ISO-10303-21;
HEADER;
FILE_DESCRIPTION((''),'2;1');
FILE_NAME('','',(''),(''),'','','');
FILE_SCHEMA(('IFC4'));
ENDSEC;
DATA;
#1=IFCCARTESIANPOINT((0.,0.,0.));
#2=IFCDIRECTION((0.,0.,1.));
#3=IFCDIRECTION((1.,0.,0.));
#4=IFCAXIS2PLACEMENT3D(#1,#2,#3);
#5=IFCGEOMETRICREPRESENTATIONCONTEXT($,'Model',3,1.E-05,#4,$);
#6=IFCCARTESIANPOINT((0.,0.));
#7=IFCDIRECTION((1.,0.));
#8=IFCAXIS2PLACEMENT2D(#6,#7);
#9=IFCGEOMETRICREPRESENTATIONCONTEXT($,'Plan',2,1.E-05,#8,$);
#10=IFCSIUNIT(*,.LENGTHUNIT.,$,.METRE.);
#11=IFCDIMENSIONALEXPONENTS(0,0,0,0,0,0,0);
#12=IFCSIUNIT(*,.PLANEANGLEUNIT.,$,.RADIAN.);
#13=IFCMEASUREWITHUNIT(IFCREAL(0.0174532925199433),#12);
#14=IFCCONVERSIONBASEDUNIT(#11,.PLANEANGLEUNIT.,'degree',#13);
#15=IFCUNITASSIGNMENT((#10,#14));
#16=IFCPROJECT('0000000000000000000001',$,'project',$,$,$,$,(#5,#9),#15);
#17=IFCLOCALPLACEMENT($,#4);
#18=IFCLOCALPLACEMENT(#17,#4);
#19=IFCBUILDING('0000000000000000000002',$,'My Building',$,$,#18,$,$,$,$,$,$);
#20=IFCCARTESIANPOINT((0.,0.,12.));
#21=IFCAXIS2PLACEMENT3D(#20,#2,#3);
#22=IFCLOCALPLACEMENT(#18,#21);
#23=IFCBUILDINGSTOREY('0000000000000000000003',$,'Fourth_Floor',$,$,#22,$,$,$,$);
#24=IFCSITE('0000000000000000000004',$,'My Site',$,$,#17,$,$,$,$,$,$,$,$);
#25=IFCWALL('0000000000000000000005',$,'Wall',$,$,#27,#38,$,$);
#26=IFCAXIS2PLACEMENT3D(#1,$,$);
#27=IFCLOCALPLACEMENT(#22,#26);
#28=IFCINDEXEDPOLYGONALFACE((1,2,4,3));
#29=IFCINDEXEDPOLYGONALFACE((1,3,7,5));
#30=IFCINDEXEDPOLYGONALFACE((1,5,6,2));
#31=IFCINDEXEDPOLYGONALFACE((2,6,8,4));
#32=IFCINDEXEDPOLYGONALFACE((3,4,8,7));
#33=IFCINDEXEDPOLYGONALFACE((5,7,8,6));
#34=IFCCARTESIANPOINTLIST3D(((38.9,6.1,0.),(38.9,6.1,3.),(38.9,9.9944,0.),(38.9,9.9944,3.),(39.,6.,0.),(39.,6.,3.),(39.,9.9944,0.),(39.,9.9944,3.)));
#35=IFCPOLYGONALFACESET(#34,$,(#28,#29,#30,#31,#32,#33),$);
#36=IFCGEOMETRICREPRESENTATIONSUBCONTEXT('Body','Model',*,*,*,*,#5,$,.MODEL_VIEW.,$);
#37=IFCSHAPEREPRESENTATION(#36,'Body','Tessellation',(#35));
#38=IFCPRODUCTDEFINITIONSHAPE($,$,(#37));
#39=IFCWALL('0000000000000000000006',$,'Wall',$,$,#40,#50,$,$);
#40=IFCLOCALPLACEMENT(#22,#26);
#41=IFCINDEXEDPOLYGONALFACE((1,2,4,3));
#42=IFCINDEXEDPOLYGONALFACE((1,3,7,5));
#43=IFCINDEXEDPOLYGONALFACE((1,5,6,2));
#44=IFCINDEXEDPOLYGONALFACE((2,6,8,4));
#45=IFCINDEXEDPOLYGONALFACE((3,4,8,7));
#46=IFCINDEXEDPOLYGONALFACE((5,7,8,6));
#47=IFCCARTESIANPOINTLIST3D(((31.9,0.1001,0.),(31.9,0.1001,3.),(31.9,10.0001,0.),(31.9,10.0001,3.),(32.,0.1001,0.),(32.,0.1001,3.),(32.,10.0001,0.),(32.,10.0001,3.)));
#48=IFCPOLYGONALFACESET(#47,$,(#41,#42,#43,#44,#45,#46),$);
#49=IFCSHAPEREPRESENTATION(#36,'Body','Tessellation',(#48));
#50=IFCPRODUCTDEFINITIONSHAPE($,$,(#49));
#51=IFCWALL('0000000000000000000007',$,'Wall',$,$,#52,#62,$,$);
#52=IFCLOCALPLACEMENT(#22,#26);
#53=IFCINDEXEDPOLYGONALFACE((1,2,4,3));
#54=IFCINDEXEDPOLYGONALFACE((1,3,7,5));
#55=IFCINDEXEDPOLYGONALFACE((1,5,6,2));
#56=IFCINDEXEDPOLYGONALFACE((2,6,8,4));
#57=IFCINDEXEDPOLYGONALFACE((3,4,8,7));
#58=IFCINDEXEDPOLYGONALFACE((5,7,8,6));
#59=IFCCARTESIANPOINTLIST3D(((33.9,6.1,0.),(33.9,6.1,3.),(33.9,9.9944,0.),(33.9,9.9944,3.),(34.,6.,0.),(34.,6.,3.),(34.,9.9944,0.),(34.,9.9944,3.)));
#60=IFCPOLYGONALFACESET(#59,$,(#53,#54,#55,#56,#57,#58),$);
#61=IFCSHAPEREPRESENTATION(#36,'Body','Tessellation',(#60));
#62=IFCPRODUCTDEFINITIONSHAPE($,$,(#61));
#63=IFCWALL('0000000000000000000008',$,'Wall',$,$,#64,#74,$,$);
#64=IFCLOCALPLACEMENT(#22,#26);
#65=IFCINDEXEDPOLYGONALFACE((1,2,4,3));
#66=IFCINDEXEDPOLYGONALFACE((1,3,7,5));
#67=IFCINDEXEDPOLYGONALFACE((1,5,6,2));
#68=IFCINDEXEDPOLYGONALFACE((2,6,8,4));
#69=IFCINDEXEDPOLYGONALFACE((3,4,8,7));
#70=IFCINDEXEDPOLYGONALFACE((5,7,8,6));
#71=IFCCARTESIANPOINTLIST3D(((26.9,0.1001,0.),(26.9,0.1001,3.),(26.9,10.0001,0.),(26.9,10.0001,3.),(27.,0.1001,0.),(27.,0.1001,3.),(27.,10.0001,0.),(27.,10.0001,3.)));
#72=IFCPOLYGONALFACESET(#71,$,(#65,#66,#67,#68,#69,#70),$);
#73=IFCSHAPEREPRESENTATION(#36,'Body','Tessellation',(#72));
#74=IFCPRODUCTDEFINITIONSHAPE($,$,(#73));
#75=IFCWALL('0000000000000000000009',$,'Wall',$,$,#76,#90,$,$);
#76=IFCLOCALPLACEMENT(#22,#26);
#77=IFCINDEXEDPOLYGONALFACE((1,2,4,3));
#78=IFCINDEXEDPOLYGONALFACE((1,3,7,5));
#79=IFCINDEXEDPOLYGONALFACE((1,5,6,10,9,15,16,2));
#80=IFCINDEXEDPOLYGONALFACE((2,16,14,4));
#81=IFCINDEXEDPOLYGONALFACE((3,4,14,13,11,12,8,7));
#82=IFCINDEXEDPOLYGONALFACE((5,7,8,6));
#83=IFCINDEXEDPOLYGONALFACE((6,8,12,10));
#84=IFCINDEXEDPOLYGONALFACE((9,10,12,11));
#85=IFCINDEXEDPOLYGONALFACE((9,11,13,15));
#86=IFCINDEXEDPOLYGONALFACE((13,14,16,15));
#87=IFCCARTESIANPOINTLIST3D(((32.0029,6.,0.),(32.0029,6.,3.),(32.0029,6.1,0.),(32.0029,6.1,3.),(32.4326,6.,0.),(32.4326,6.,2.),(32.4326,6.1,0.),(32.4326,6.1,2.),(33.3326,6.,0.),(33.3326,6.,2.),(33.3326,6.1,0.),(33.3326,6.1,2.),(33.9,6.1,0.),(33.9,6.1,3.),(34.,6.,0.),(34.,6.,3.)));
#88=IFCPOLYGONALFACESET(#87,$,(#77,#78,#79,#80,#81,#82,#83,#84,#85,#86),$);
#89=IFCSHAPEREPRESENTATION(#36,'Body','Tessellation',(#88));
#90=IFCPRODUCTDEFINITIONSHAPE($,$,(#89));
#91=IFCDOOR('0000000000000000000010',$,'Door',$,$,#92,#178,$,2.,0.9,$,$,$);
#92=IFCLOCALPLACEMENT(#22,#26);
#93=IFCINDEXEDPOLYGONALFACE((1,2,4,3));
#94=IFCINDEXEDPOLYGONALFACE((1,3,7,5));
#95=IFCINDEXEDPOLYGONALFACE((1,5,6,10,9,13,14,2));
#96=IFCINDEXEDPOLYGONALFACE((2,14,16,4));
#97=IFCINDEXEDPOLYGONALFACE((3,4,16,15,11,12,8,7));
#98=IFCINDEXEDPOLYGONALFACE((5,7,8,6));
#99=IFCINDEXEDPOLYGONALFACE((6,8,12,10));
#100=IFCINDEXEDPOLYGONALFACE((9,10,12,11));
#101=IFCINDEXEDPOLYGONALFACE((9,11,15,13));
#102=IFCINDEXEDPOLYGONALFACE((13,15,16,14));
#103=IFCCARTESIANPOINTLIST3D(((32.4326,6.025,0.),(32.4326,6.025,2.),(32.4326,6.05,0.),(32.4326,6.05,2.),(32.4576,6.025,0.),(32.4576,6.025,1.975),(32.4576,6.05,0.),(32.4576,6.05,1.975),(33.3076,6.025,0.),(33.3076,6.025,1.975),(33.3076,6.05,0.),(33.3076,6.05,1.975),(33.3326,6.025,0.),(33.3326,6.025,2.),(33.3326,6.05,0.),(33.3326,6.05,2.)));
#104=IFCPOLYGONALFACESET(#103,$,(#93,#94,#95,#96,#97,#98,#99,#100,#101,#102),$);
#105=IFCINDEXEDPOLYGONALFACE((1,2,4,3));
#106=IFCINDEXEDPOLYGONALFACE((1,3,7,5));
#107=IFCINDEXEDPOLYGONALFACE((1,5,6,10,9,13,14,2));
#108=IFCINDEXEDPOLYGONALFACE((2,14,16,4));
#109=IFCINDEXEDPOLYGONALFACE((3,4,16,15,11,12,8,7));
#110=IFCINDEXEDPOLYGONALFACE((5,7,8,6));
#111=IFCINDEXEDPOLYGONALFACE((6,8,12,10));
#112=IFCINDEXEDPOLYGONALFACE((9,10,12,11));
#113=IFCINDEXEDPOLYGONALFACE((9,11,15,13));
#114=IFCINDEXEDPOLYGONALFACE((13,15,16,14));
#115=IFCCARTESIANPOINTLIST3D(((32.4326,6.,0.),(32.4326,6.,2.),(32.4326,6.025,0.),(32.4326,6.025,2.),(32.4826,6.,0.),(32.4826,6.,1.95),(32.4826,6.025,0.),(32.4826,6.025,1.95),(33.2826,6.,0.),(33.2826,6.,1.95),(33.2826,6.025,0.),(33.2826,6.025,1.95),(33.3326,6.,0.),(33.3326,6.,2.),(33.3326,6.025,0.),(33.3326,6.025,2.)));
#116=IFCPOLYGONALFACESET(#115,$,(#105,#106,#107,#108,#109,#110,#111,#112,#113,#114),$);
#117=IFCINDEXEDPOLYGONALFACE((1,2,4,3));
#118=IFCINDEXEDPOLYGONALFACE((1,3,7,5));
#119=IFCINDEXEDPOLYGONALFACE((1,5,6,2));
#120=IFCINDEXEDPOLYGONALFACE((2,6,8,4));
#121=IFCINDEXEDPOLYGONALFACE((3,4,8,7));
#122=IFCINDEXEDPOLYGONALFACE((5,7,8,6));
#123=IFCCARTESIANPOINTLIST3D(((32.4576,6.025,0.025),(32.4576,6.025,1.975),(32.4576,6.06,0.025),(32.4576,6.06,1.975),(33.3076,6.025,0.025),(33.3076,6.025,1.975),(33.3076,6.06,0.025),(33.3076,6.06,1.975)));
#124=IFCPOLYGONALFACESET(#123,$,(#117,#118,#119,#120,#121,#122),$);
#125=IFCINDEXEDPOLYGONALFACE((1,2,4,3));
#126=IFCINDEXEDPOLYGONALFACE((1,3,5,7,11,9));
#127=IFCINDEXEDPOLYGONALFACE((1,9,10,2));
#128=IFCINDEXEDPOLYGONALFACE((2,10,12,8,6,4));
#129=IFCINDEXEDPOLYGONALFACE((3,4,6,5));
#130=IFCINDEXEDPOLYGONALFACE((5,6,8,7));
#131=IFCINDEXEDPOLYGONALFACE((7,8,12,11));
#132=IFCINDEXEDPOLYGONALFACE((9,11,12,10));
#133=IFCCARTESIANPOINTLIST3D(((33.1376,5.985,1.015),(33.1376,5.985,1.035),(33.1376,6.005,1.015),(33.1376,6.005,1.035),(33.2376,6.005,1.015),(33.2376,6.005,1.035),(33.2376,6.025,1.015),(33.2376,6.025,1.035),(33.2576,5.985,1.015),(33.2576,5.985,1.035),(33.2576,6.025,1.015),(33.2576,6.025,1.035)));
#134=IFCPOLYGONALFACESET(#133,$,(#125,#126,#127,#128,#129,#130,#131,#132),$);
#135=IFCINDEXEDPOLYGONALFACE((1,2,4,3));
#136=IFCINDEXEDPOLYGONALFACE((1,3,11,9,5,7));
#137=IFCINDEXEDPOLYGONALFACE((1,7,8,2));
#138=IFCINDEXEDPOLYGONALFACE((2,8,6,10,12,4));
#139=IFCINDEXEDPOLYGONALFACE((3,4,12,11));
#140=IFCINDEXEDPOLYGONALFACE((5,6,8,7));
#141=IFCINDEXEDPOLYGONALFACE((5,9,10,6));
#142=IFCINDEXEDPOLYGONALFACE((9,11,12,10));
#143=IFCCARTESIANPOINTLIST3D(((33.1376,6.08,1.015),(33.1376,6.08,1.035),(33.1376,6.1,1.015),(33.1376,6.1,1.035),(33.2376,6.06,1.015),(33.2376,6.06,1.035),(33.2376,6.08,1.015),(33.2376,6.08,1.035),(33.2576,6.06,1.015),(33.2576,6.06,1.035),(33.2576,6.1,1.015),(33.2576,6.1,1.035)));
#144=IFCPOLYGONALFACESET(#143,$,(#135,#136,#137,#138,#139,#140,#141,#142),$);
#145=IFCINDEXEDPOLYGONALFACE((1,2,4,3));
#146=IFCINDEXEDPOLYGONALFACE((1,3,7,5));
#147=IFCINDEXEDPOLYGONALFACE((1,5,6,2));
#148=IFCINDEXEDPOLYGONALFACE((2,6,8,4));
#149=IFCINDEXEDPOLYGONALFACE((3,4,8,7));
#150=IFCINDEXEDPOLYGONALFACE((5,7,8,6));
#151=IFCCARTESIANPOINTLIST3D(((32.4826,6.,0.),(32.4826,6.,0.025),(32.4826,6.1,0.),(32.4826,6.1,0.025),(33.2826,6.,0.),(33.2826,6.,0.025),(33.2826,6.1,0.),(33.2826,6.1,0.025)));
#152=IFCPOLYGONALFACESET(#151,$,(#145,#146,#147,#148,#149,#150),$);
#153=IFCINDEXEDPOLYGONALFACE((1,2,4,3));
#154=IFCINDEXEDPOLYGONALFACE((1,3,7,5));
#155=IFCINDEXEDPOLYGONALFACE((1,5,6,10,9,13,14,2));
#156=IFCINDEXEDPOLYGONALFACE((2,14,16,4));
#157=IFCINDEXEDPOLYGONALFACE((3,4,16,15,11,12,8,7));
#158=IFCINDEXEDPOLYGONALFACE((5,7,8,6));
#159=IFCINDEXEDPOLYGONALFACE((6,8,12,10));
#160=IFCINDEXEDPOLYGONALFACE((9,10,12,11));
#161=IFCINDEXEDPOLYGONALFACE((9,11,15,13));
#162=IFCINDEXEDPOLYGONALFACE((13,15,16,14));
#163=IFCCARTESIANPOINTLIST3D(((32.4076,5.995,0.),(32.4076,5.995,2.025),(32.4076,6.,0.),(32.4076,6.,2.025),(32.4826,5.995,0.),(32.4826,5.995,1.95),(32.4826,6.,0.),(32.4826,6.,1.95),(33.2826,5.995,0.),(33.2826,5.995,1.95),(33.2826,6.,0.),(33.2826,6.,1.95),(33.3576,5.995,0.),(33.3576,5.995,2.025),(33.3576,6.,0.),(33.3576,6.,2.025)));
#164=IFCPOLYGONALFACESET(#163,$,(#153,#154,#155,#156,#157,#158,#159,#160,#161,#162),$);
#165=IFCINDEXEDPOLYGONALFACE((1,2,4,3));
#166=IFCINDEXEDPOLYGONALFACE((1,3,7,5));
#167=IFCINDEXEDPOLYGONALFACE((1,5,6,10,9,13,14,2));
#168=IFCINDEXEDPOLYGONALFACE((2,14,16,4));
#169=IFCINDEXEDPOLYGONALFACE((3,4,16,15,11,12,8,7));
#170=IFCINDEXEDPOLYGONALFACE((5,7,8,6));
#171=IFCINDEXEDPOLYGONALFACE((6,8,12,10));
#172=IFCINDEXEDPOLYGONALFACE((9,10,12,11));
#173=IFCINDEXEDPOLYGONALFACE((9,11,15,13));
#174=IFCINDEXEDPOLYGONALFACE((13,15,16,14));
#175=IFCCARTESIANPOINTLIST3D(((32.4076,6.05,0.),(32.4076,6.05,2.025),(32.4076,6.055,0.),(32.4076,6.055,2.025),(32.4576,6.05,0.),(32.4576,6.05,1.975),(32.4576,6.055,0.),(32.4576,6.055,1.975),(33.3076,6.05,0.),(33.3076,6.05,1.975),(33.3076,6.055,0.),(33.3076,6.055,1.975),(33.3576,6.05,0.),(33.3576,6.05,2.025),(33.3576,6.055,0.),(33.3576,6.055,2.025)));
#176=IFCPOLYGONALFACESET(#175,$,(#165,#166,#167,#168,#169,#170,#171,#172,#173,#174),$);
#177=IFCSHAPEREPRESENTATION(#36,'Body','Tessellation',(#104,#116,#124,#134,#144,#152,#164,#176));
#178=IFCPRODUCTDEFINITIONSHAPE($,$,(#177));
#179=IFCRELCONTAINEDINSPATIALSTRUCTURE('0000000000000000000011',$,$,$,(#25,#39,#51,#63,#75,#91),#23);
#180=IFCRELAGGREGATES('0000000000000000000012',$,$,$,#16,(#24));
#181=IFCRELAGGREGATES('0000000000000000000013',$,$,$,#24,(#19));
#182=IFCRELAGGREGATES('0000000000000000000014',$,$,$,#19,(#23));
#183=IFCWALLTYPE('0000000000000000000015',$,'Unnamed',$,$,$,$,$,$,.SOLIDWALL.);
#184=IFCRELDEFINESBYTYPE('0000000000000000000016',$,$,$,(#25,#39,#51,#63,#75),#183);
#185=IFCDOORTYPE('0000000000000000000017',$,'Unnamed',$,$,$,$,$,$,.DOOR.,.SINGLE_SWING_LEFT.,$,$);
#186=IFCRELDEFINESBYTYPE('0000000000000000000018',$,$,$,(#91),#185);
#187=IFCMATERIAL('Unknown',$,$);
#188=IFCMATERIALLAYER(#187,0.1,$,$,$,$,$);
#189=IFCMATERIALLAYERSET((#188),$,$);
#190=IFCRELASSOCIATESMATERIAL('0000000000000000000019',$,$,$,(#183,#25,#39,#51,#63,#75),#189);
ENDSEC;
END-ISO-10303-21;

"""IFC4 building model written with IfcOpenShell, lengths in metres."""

from ifc_helpers import new_model, entity, si_unit, converted_unit, frame, origin_with_axes, origin_2d_with_axis, place, context, subcontext, project, spatial, line, indexed_curve, outline, extrude, shape, source, transform, mapped, material, layer, layer_set, layer_usage, type_object, type_shapes, element, fill, save


model = new_model("IFC4")

# Units and contexts
model_context = context("Model", 3, precision=1e-05, world=origin_with_axes())
plan_context = context("Plan", 2, precision=1e-05, world=origin_2d_with_axis())
body_context_1 = subcontext(model_context, "Body", "Model", "MODEL_VIEW")
body_context_2 = subcontext(plan_context, "Body", "Plan", "PLAN_VIEW")
ifc_project = project(units=[si_unit("LENGTHUNIT", "METRE"), converted_unit("PLANEANGLEUNIT", "degree", entity("IfcReal", 0.0174532925199433), si_unit("PLANEANGLEUNIT", "RADIAN"), dimensions=[0, 0, 0, 0, 0, 0, 0])], contexts=[model_context, plan_context])

# Site, building, storey
site_placement = place(None, origin_with_axes())
site = spatial("IfcSite", under=ifc_project, at=site_placement, Name="My Site")
building_placement = place(site_placement, origin_with_axes())
building = spatial("IfcBuilding", under=site, at=building_placement, Name="My Building")
storey_placement = place(building_placement, frame((0.0, 0.0, 12.0), z_axis=(0.0, 0.0, 1.0), x_axis=(1.0, 0.0, 0.0)))
storey = spatial("IfcBuildingStorey", under=building, at=storey_placement, Name="Fourth_Floor")

# Walls
ifc_material = material(Name="Unknown")
ifc_layer = layer(ifc_material, 0.1)
ifc_layer_set = layer_set([ifc_layer])
ifc_layer_usage_1 = layer_usage(ifc_layer_set, "AXIS2", "POSITIVE", 0.0)
wall_type = type_object("IfcWallType", Name="Unnamed", PredefinedType="SOLIDWALL", material=ifc_layer_set)
wall_1_placement = place(storey_placement, frame((39.0, 6.0, 0.0), z_axis=(0.0, 0.0, 1.0), x_axis=(0.0, 1.0, 0.0)))
element("IfcWall", 1, at=wall_1_placement, inside=storey, type_object=wall_type, material=ifc_layer_usage_1, Name="Wall", context=body_context_1, shape_type="SweptSolid", body=[
    extrude(outline(indexed_curve([(0.0, 0.0), (0.1, 0.1), (3.9944, 0.1), (3.9944, 0.0)], segments=[line(1, 2, 3, 4, 1)])), origin_with_axes(), (0.0, 0.0, 1.0), 3.0),
])
ifc_layer_usage_2 = layer_usage(ifc_layer_set, "AXIS2", "POSITIVE", 0.0)
wall_2_placement = place(storey_placement, frame((31.9, 10.0001, 0.0), z_axis=(0.0, 0.0, 1.0), x_axis=(0.0, -1.0, 0.0)))
element("IfcWall", 2, at=wall_2_placement, inside=storey, type_object=wall_type, material=ifc_layer_usage_2, Name="Wall", context=body_context_1, shape_type="SweptSolid", body=[
    extrude(outline(indexed_curve([(0.0, 0.0), (0.0, 0.1), (9.9, 0.1), (9.9, 0.0)], segments=[line(1, 2, 3, 4, 1)])), origin_with_axes(), (0.0, 0.0, 1.0), 3.0),
])
ifc_layer_usage_3 = layer_usage(ifc_layer_set, "AXIS2", "POSITIVE", 0.0)
wall_3_placement = place(storey_placement, frame((34.0, 6.0, 0.0), z_axis=(0.0, 0.0, 1.0), x_axis=(0.0, 1.0, 0.0)))
element("IfcWall", 3, at=wall_3_placement, inside=storey, type_object=wall_type, material=ifc_layer_usage_3, Name="Wall", context=body_context_1, shape_type="SweptSolid", body=[
    extrude(outline(indexed_curve([(0.0, 0.0), (0.1, 0.1), (3.9944, 0.1), (3.9944, 0.0)], segments=[line(1, 2, 3, 4, 1)])), origin_with_axes(), (0.0, 0.0, 1.0), 3.0),
])
ifc_layer_usage_4 = layer_usage(ifc_layer_set, "AXIS2", "POSITIVE", 0.0)
wall_4_placement = place(storey_placement, frame((26.9, 10.0001, 0.0), z_axis=(0.0, 0.0, 1.0), x_axis=(0.0, -1.0, 0.0)))
element("IfcWall", 4, at=wall_4_placement, inside=storey, type_object=wall_type, material=ifc_layer_usage_4, Name="Wall", context=body_context_1, shape_type="SweptSolid", body=[
    extrude(outline(indexed_curve([(0.0, 0.0), (0.0, 0.1), (9.9, 0.1), (9.9, 0.0)], segments=[line(1, 2, 3, 4, 1)])), origin_with_axes(), (0.0, 0.0, 1.0), 3.0),
])

# Wall, opening, door
ifc_layer_usage_5 = layer_usage(ifc_layer_set, "AXIS2", "POSITIVE", 0.0)
wall_5_placement = place(storey_placement, frame((32.0029, 6.0, 0.0), z_axis=(0.0, 0.0, 1.0), x_axis=(1.0, 0.0, 0.0)))
wall_5 = element("IfcWall", 5, at=wall_5_placement, inside=storey, type_object=wall_type, material=ifc_layer_usage_5, Name="Wall", context=body_context_1, shape_type="SweptSolid", body=[
    extrude(outline(indexed_curve([(0.0, 0.0), (0.0, 0.1), (1.8971, 0.1), (1.9971, 0.0)], segments=[line(1, 2, 3, 4, 1)])), origin_with_axes(), (0.0, 0.0, 1.0), 3.0),
])
shared_shape_1 = source(origin_with_axes(), body_context_1, "Body", "SweptSolid", [
    extrude(outline(indexed_curve([(0.0, 0.0), (0.9, 0.0), (0.9, 2.0), (0.0, 2.0)], segments=[line(1, 2, 3, 4, 1)])), frame((0.0, -0.6, 0.0), z_axis=(0.0, -1.0, 0.0), x_axis=(1.0, 0.0, 0.0)), (0.0, 0.0, -1.0), 1.2),
])
opening_1_placement = place(wall_5_placement, frame((0.4297, 0.0, 0.0), z_axis=(0.0, 0.0, 1.0), x_axis=(1.0, 0.0, 0.0)))
opening_1 = element("IfcOpeningElement", 6, at=opening_1_placement, cuts=wall_5, PredefinedType="OPENING", context=body_context_1, shape_type="MappedRepresentation", body=[
    mapped(shared_shape_1, transform((0.0, 0.0, 0.0), x_axis=(1.0, 0.0, 0.0), y_axis=(0.0, 1.0, 0.0), z_axis=(0.0, 0.0, 1.0), scale=1.0)),
])
door_type = type_object("IfcDoorType", Name="Unnamed", OperationType="SINGLE_SWING_LEFT", PredefinedType="DOOR")
shared_shape_2 = source(origin_with_axes(), body_context_1, "Body", "SweptSolid", [
    extrude(outline(indexed_curve([(0.0, 0.0), (0.0, 2.0), (0.9, 2.0), (0.9, 0.0), (0.875, 0.0), (0.875, 1.975), (0.025, 1.975), (0.025, 0.0)], segments=[line(1, 2, 3, 4, 5, 6, 7, 8, 1)])), frame((0.0, 0.025, 0.0), z_axis=(0.0, -1.0, 0.0), x_axis=(1.0, 0.0, 0.0)), (0.0, 0.0, -1.0), 0.025),
    extrude(outline(indexed_curve([(0.0, 0.0), (0.0, 2.0), (0.9, 2.0), (0.9, 0.0), (0.85, 0.0), (0.85, 1.95), (0.05, 1.95), (0.05, 0.0)], segments=[line(1, 2, 3, 4, 5, 6, 7, 8, 1)])), frame((0.0, 0.0, 0.0), z_axis=(0.0, -1.0, 0.0), x_axis=(1.0, 0.0, 0.0)), (0.0, 0.0, -1.0), 0.025),
    extrude(outline(indexed_curve([(0.0, 0.0), (0.85, 0.0), (0.85, 0.035), (0.0, 0.035)], segments=[line(1, 2, 3, 4, 1)])), frame((0.025, 0.025, 0.025), z_axis=(0.0, 0.0, 1.0), x_axis=(1.0, 0.0, 0.0)), (0.0, 0.0, 1.0), 1.95),
    extrude(outline(indexed_curve([(0.0, 0.0), (0.0, -0.04), (-0.12, -0.04), (-0.12, -0.02), (-0.02, -0.02), (-0.02, 0.0)], segments=[line(1, 2, 3, 4, 5, 6, 1)])), frame((0.825, 0.025, 1.015), z_axis=(0.0, 0.0, 1.0), x_axis=(1.0, 0.0, 0.0)), (0.0, 0.0, 1.0), 0.02),
    extrude(outline(indexed_curve([(0.0, 0.0), (0.0, 0.04), (-0.12, 0.04), (-0.12, 0.02), (-0.02, 0.02), (-0.02, 0.0)], segments=[line(1, 2, 3, 4, 5, 6, 1)])), frame((0.825, 0.06, 1.015), z_axis=(0.0, 0.0, 1.0), x_axis=(1.0, 0.0, 0.0)), (0.0, 0.0, 1.0), 0.02),
    extrude(outline(indexed_curve([(0.0, 0.0), (0.8, 0.0), (0.8, 0.1), (0.0, 0.1)], segments=[line(1, 2, 3, 4, 1)])), frame((0.05, 0.0, 0.0), z_axis=(0.0, 0.0, 1.0), x_axis=(1.0, 0.0, 0.0)), (0.0, 0.0, 1.0), 0.025),
    extrude(outline(indexed_curve([(0.0, 0.0), (0.0, 2.025), (0.95, 2.025), (0.95, 0.0), (0.875, 0.0), (0.875, 1.95), (0.075, 1.95), (0.075, 0.0)], segments=[line(1, 2, 3, 4, 5, 6, 7, 8, 1)])), frame((-0.025, -0.005, 0.0), z_axis=(0.0, -1.0, 0.0), x_axis=(1.0, 0.0, 0.0)), (0.0, 0.0, -1.0), 0.005),
    extrude(outline(indexed_curve([(0.0, 0.0), (0.0, 2.025), (0.95, 2.025), (0.95, 0.0), (0.9, 0.0), (0.9, 1.975), (0.05, 1.975), (0.05, 0.0)], segments=[line(1, 2, 3, 4, 5, 6, 7, 8, 1)])), frame((-0.025, 0.05, 0.0), z_axis=(0.0, -1.0, 0.0), x_axis=(1.0, 0.0, 0.0)), (0.0, 0.0, -1.0), 0.005),
])
shared_shape_3 = source(origin_with_axes(), body_context_2, "Body", "Curve2D", [
    entity("IfcIndexedPolyCurve", entity("IfcCartesianPointList2D", [[0.0, 0.0], [0.0, 0.05], [0.025, 0.05], [0.025, 0.025], [0.05, 0.025], [0.05, 0.0]]), [entity("IfcLineIndex", [1, 2, 3, 4, 5, 6, 1])]),
    entity("IfcIndexedPolyCurve", entity("IfcCartesianPointList2D", [[0.9, 0.0], [0.9, 0.05], [0.875, 0.05], [0.875, 0.025], [0.85, 0.025], [0.85, 0.0]]), [entity("IfcLineIndex", [1, 2, 3, 4, 5, 6, 1])]),
    entity("IfcTrimmedCurve", entity("IfcEllipse", entity("IfcAxis2Placement2D", entity("IfcCartesianPoint", [0.06, 0.05]), entity("IfcDirection", [1.0, 0.0])), 0.815, 0.85), [entity("IfcCartesianPoint", [0.875, 0.05])], [entity("IfcCartesianPoint", [0.06, 0.9])], True, "CARTESIAN"),
    entity("IfcIndexedPolyCurve", entity("IfcCartesianPointList2D", [[0.025, 0.05], [0.06, 0.05], [0.06, 0.9], [0.025, 0.9]]), [entity("IfcLineIndex", [1, 2, 3, 4, 1])]),
])
type_shapes(door_type, [shared_shape_2, shared_shape_3])
door_1_placement = place(opening_1_placement, origin_with_axes())
door_1 = element("IfcDoor", 7, at=door_1_placement, inside=storey, type_object=door_type, Name="Door", OverallHeight=2.0, OverallWidth=0.9, shapes=[
    shape(body_context_1, "Body", "MappedRepresentation", [mapped(shared_shape_2, transform((0.0, 0.0, 0.0), x_axis=(1.0, 0.0, 0.0), y_axis=(0.0, 1.0, 0.0), z_axis=(0.0, 0.0, 1.0), scale=1.0))]),
    shape(body_context_2, "Body", "MappedRepresentation", [mapped(shared_shape_3, transform((0.0, 0.0, 0.0), x_axis=(1.0, 0.0, 0.0), y_axis=(0.0, 1.0, 0.0), z_axis=(0.0, 0.0, 1.0), scale=1.0))]),
])
fill(opening_1, door_1)

save(model, "model.ifc")
